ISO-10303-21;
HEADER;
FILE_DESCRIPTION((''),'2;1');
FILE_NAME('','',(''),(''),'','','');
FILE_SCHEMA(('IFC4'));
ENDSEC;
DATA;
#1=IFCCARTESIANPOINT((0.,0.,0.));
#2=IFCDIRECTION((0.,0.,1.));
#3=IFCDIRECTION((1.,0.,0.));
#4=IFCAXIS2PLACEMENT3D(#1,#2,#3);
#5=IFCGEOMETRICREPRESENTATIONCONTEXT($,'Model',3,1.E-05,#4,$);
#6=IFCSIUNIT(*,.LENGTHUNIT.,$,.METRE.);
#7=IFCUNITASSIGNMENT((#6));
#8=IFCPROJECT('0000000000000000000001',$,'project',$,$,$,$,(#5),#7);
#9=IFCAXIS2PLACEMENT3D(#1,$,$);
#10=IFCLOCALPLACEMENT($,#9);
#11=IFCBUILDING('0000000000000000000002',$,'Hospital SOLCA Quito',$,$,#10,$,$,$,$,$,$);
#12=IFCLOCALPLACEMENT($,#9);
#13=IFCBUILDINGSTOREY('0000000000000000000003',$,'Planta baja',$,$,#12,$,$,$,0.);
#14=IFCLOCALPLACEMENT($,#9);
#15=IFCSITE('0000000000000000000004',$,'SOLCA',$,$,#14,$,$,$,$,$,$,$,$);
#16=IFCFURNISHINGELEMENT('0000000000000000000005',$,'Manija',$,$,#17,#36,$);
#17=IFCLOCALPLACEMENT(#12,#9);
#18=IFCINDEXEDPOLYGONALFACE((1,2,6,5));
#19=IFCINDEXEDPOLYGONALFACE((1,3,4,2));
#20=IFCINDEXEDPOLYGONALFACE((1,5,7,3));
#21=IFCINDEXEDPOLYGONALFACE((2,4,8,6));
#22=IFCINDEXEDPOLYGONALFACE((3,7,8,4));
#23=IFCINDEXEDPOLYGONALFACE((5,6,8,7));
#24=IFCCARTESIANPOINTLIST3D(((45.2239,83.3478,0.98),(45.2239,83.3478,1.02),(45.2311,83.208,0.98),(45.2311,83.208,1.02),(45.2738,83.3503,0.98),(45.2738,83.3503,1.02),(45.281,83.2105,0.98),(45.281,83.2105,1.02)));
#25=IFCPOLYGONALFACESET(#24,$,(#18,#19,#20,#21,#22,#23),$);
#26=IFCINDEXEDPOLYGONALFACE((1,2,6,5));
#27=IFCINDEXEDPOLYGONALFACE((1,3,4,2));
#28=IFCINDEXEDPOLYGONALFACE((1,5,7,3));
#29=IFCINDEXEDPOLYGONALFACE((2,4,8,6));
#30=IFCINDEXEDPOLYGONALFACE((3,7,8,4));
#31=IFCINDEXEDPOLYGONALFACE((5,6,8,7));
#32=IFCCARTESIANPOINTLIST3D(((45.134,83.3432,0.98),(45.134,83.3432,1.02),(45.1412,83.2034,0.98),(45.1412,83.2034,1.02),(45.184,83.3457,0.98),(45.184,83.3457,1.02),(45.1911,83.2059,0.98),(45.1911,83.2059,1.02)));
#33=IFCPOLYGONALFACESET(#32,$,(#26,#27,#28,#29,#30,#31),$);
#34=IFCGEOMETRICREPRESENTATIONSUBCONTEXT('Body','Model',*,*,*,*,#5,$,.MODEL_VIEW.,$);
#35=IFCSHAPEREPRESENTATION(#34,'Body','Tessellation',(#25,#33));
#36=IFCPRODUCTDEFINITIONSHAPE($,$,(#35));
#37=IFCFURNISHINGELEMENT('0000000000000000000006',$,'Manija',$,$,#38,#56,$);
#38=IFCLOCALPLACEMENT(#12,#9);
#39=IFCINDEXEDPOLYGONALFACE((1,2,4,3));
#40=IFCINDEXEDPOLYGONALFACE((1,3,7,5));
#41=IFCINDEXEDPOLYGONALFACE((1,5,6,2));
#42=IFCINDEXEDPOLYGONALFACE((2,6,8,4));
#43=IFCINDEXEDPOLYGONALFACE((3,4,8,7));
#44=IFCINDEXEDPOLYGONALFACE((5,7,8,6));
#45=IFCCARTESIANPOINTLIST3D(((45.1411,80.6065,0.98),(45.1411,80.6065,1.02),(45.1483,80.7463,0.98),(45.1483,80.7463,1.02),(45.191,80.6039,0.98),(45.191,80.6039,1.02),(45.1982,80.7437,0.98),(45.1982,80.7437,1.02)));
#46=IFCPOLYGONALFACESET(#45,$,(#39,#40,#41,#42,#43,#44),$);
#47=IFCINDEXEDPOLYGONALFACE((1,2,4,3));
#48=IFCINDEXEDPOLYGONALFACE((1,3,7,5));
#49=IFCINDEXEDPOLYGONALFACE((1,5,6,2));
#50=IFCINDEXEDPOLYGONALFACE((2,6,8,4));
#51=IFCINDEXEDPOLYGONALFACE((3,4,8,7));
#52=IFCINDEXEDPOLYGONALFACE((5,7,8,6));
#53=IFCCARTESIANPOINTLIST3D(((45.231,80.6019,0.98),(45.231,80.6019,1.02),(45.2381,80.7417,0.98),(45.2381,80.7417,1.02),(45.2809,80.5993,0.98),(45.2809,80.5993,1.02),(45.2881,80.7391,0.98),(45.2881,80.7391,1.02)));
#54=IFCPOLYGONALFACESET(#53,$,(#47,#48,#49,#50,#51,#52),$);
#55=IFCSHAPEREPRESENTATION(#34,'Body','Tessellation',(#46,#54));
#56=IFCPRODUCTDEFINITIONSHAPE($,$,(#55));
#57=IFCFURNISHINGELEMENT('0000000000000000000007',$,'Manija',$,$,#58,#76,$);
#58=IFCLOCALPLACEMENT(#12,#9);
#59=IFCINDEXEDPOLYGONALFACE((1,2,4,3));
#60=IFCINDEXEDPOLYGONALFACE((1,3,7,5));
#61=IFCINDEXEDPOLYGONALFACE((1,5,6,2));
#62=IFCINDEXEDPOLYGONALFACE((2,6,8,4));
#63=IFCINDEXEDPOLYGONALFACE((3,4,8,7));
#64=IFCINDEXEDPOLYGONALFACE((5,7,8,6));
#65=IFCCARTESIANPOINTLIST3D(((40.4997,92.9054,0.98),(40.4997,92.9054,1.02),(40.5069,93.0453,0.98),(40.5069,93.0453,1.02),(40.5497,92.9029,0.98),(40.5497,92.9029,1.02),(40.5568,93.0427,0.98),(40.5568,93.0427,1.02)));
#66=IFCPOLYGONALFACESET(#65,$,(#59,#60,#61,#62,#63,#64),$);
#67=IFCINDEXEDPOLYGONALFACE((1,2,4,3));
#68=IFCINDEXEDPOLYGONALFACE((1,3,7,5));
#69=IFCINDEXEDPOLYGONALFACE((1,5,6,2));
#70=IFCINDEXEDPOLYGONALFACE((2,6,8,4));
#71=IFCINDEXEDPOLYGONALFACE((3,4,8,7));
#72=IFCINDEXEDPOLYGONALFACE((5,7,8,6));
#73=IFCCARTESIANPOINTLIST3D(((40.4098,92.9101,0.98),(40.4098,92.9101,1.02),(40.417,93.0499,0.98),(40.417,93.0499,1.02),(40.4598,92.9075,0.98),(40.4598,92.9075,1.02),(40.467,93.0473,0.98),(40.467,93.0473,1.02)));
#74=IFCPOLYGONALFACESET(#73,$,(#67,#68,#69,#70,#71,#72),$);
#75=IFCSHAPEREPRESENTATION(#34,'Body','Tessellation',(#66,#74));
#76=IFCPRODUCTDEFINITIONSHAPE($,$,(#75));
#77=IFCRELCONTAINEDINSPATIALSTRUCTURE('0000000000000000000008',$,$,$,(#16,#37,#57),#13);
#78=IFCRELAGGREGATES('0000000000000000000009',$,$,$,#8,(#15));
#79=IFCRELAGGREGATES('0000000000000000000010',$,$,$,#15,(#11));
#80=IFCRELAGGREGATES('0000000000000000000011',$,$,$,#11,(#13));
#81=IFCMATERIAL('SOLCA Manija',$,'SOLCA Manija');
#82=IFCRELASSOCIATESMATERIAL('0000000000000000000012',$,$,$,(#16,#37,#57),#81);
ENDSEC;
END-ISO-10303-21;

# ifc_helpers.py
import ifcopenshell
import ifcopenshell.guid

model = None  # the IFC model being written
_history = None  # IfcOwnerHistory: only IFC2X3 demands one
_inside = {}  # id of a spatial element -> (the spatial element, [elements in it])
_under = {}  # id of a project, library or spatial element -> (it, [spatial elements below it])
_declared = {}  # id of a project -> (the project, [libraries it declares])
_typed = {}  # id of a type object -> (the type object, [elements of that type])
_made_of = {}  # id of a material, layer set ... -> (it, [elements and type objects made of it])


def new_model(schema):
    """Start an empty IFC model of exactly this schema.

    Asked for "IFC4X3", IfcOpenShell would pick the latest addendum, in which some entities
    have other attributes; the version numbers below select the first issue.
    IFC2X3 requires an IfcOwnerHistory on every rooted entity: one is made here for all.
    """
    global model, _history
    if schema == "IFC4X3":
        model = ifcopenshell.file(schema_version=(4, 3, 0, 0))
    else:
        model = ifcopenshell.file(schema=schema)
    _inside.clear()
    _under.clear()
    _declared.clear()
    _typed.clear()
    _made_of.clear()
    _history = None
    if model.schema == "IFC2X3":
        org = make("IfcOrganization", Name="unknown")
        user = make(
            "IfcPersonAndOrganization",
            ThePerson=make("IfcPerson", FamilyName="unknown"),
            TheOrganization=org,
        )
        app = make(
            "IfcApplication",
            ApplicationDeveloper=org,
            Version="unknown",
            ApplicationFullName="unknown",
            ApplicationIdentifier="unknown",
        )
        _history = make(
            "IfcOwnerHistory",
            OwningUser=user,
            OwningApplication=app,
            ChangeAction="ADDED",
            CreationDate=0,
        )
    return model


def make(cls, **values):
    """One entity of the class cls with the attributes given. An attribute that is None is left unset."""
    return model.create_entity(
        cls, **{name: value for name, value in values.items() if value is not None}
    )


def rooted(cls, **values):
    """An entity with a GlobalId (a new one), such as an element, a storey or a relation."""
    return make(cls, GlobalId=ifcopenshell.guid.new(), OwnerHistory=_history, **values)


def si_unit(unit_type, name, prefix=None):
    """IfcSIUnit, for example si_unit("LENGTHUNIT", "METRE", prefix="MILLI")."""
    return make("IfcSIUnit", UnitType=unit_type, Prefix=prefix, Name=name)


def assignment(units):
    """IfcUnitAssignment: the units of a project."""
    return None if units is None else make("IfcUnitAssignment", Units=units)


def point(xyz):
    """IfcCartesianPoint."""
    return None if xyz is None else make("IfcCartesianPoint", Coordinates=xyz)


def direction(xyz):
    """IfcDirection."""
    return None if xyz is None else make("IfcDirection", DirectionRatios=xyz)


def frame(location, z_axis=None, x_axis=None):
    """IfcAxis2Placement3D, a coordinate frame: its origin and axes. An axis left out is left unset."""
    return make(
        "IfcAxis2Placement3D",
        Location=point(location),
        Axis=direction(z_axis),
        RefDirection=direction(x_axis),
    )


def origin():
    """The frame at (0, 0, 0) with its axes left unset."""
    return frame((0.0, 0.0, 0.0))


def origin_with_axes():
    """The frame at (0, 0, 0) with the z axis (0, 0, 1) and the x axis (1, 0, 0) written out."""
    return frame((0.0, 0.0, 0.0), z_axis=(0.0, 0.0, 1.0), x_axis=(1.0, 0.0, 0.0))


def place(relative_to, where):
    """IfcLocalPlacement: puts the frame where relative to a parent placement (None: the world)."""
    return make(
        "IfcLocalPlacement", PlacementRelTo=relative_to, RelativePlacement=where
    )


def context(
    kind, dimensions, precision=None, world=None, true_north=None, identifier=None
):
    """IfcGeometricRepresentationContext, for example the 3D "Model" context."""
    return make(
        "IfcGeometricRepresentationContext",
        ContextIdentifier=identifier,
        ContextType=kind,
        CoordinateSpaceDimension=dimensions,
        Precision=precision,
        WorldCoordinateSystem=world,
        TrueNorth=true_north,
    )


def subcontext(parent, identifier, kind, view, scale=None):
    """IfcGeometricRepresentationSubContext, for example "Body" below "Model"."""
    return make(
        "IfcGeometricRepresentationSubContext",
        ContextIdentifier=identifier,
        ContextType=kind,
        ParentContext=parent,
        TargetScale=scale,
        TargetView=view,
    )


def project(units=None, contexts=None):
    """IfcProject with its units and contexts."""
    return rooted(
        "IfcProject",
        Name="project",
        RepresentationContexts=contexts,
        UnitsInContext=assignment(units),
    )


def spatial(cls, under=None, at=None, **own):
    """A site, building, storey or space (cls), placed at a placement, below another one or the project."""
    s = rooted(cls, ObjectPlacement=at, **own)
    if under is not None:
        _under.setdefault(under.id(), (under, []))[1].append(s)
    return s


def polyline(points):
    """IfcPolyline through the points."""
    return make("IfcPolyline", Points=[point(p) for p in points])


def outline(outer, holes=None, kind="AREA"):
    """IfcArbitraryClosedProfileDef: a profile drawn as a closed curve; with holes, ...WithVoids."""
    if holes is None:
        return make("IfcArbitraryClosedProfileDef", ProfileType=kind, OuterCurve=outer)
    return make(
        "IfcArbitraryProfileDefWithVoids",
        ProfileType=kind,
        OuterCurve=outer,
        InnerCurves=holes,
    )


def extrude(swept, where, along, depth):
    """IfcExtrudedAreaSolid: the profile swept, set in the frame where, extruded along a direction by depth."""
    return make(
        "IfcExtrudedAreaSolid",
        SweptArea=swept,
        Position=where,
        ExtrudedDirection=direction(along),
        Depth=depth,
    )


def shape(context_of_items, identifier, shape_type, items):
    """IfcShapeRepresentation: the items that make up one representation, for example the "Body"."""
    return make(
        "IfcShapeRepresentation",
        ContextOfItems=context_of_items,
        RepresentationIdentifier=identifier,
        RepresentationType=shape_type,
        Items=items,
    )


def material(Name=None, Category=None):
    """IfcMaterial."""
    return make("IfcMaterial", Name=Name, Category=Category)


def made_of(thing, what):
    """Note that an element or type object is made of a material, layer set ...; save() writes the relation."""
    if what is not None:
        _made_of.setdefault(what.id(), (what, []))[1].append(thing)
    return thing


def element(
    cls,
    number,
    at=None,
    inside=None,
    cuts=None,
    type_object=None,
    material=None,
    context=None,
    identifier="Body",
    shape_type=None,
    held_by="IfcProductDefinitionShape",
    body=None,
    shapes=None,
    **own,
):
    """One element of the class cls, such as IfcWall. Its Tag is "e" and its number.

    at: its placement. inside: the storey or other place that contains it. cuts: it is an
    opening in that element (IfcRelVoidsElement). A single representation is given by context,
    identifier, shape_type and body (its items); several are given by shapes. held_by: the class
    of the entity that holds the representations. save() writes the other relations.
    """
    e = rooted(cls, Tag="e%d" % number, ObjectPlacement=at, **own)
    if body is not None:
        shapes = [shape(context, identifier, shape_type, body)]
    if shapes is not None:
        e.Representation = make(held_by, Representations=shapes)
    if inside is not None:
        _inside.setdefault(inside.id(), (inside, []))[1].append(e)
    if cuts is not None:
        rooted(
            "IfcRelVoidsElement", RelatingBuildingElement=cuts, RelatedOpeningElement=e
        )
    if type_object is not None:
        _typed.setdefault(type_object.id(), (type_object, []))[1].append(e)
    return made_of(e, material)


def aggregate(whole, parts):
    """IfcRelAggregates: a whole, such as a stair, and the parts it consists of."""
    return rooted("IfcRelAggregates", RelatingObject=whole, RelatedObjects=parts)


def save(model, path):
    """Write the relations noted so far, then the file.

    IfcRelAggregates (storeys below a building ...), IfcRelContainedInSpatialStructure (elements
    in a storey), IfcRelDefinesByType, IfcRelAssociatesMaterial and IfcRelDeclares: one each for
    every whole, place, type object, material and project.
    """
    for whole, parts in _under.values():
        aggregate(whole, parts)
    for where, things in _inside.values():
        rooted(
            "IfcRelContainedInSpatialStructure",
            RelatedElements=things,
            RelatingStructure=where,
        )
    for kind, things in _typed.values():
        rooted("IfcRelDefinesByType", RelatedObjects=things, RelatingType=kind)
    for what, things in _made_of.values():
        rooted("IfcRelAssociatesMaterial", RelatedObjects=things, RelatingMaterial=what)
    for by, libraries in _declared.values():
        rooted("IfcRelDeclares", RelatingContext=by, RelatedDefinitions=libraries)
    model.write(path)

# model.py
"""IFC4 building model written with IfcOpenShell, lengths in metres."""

from ifc_helpers import new_model, si_unit, frame, origin, origin_with_axes, place, context, subcontext, project, spatial, polyline, outline, extrude, material, element, save


model = new_model("IFC4")

# Units and contexts
model_context = context("Model", 3, precision=1e-05, world=origin_with_axes())
body_context = subcontext(model_context, "Body", "Model", "MODEL_VIEW")
ifc_project = project(units=[si_unit("LENGTHUNIT", "METRE")], contexts=[model_context])

# Site, building, storey
site_placement = place(None, origin())
site = spatial("IfcSite", under=ifc_project, at=site_placement, Name="SOLCA")
building_placement = place(None, origin())
building = spatial("IfcBuilding", under=site, at=building_placement, Name="Hospital SOLCA Quito")
storey_placement = place(None, origin())
storey = spatial("IfcBuildingStorey", under=building, at=storey_placement, Name="Planta baja", Elevation=0.0)

# Furnishing elements
ifc_material_1 = material(Name="SOLCA Manija", Category="SOLCA Manija")
furnishing_1_placement = place(storey_placement, origin_with_axes())
element("IfcFurnishingElement", 1, at=furnishing_1_placement, inside=storey, material=ifc_material_1, Name="Manija", context=body_context, shape_type="SweptSolid", body=[
    extrude(outline(polyline([(45.281, 83.2105), (45.2738, 83.3503), (45.2239, 83.3478), (45.2311, 83.208), (45.281, 83.2105)])), frame((0.0, 0.0, 0.98), z_axis=(0.0, 0.0, 1.0), x_axis=(1.0, 0.0, 0.0)), (0.0, 0.0, 1.0), 0.04),
    extrude(outline(polyline([(45.1911, 83.2059), (45.184, 83.3457), (45.134, 83.3432), (45.1412, 83.2034), (45.1911, 83.2059)])), frame((0.0, 0.0, 0.98), z_axis=(0.0, 0.0, 1.0), x_axis=(1.0, 0.0, 0.0)), (0.0, 0.0, 1.0), 0.04),
])
furnishing_2_placement = place(storey_placement, origin_with_axes())
element("IfcFurnishingElement", 2, at=furnishing_2_placement, inside=storey, material=ifc_material_1, Name="Manija", context=body_context, shape_type="SweptSolid", body=[
    extrude(outline(polyline([(45.1483, 80.7463), (45.1411, 80.6065), (45.191, 80.6039), (45.1982, 80.7437), (45.1483, 80.7463)])), frame((0.0, 0.0, 0.98), z_axis=(0.0, 0.0, 1.0), x_axis=(1.0, 0.0, 0.0)), (0.0, 0.0, 1.0), 0.04),
    extrude(outline(polyline([(45.2381, 80.7417), (45.231, 80.6019), (45.2809, 80.5993), (45.2881, 80.7391), (45.2381, 80.7417)])), frame((0.0, 0.0, 0.98), z_axis=(0.0, 0.0, 1.0), x_axis=(1.0, 0.0, 0.0)), (0.0, 0.0, 1.0), 0.04),
])
furnishing_3_placement = place(storey_placement, origin_with_axes())
element("IfcFurnishingElement", 3, at=furnishing_3_placement, inside=storey, material=ifc_material_1, Name="Manija", context=body_context, shape_type="SweptSolid", body=[
    extrude(outline(polyline([(40.5497, 92.9029), (40.5568, 93.0427), (40.5069, 93.0453), (40.4997, 92.9054), (40.5497, 92.9029)])), frame((0.0, 0.0, 0.98), z_axis=(0.0, 0.0, 1.0), x_axis=(1.0, 0.0, 0.0)), (0.0, 0.0, 1.0), 0.04),
    extrude(outline(polyline([(40.4598, 92.9075), (40.467, 93.0473), (40.417, 93.0499), (40.4098, 92.9101), (40.4598, 92.9075)])), frame((0.0, 0.0, 0.98), z_axis=(0.0, 0.0, 1.0), x_axis=(1.0, 0.0, 0.0)), (0.0, 0.0, 1.0), 0.04),
])

save(model, "model.ifc")
